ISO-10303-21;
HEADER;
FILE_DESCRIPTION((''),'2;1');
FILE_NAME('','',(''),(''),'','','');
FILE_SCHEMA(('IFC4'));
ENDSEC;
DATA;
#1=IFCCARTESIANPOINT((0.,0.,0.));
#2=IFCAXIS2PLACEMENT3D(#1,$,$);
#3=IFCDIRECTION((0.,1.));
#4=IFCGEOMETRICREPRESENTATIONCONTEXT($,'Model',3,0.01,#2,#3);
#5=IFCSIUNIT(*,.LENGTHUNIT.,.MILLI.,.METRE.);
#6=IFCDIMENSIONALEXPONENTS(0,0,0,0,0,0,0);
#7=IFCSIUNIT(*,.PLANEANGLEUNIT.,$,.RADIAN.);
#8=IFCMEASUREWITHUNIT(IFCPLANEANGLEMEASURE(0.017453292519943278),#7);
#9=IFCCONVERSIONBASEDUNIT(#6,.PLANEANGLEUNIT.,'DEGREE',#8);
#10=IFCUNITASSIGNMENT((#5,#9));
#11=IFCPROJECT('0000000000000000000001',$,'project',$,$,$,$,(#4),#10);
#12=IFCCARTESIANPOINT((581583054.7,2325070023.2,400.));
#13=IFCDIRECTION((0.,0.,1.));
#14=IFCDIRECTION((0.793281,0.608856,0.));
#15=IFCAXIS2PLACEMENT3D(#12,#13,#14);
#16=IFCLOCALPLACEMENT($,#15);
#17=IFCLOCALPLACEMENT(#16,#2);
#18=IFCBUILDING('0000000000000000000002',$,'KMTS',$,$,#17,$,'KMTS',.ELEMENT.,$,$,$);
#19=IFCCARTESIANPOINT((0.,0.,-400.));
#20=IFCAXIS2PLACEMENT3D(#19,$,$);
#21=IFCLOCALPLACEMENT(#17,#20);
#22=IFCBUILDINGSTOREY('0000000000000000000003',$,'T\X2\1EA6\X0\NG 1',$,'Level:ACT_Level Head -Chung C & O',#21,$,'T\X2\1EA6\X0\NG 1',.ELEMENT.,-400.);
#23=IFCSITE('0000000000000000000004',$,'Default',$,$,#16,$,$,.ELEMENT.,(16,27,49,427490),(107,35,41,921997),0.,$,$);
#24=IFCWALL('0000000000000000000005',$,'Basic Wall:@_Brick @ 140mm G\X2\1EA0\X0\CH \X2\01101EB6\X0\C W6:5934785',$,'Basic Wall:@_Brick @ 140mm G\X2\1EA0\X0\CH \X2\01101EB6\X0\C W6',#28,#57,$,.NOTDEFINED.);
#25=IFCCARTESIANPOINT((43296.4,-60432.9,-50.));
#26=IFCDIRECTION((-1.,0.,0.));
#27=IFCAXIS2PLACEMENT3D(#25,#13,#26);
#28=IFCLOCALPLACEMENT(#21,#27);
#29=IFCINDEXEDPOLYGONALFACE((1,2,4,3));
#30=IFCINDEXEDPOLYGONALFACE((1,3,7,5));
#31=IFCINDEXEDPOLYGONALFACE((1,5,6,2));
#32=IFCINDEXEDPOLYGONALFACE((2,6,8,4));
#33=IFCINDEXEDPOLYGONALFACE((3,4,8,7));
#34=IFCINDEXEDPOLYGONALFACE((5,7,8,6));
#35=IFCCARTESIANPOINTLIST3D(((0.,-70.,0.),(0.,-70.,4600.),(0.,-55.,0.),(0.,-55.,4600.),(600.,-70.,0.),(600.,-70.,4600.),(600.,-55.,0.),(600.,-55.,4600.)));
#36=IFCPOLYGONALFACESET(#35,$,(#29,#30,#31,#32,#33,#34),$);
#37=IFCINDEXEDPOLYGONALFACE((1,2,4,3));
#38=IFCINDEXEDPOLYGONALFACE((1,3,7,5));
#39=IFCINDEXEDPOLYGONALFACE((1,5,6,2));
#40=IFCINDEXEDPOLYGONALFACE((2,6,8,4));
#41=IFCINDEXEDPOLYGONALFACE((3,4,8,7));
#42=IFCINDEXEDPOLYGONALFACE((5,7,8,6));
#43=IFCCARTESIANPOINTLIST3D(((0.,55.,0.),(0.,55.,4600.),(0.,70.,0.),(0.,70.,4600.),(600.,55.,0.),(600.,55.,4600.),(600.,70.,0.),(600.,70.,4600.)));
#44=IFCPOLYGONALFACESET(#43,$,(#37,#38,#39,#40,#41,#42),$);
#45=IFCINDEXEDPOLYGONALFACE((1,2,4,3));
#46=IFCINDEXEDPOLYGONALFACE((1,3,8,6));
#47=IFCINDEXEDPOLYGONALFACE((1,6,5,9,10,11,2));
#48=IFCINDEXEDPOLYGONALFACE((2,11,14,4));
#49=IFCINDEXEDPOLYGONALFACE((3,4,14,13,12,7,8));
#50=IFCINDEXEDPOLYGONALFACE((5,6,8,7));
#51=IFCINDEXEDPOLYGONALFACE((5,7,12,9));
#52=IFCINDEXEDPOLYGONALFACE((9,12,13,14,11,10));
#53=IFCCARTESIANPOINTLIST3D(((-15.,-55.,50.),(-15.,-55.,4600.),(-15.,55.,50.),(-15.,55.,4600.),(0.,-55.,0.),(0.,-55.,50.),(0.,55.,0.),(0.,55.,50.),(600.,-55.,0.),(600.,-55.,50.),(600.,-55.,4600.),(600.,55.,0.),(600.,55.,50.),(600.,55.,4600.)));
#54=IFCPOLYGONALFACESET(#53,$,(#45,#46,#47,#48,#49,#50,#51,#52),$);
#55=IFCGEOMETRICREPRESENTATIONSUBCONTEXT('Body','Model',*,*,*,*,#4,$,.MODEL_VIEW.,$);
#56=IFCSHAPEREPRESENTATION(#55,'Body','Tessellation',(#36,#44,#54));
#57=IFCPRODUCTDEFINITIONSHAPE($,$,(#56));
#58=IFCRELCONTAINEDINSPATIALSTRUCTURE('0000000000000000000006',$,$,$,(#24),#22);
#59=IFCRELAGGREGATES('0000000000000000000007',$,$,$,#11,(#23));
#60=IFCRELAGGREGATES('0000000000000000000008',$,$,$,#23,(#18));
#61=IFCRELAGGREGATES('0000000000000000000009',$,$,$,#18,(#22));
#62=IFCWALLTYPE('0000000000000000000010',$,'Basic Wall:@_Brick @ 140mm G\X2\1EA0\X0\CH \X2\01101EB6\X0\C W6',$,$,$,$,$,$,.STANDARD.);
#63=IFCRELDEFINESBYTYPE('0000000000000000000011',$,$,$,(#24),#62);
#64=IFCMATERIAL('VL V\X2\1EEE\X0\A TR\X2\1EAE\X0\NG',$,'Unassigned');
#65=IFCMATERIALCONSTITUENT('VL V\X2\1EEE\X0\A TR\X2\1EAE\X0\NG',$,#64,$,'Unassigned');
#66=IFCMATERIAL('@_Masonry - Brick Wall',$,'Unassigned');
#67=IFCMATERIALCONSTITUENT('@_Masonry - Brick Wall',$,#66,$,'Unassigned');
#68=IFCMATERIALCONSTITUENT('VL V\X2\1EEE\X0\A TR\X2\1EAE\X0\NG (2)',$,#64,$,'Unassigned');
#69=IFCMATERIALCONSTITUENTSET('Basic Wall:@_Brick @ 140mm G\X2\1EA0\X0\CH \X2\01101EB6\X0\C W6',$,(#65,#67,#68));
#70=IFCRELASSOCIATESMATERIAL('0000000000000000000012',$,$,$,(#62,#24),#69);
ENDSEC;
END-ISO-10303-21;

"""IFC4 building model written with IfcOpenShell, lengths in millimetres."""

from ifc_helpers import new_model, entity, si_unit, converted_unit, direction, frame, origin, place, context, subcontext, project, spatial, indexed_curve, outline, extrude, material, constituent, constituent_set, type_object, element, save


model = new_model("IFC4")

# Units and contexts
model_context = context("Model", 3, precision=0.01, world=origin(), true_north=direction((0.0, 1.0)))
body_context = subcontext(model_context, "Body", "Model", "MODEL_VIEW")
ifc_project = project(units=[si_unit("LENGTHUNIT", "METRE", prefix="MILLI"), converted_unit("PLANEANGLEUNIT", "DEGREE", entity("IfcPlaneAngleMeasure", 0.017453292519943278), si_unit("PLANEANGLEUNIT", "RADIAN"), dimensions=[0, 0, 0, 0, 0, 0, 0])], contexts=[model_context])

# Site, building, storey
site_placement = place(None, frame((581583054.7, 2325070023.2, 400.0), z_axis=(0.0, 0.0, 1.0), x_axis=(0.793281, 0.608856, 0.0)))
site = spatial("IfcSite", under=ifc_project, at=site_placement, Name="Default", CompositionType="ELEMENT", RefLatitude=(16, 27, 49, 427490), RefLongitude=(107, 35, 41, 921997), RefElevation=0.0)
building_placement = place(site_placement, origin())
building = spatial("IfcBuilding", under=site, at=building_placement, Name="KMTS", LongName="KMTS", CompositionType="ELEMENT")
storey_placement = place(building_placement, frame((0.0, 0.0, -400.0)))
storey = spatial("IfcBuildingStorey", under=building, at=storey_placement, Name="TẦNG 1", ObjectType="Level:ACT_Level Head -Chung C & O", LongName="TẦNG 1", CompositionType="ELEMENT", Elevation=-400.0)

# Shared definitions
ifc_material_1 = material(Name="VL VỮA TRẮNG", Category="Unassigned")

# Wall
ifc_constituent_1 = constituent(ifc_material_1, Name="VL VỮA TRẮNG", Category="Unassigned")
ifc_material_2 = material(Name="@_Masonry - Brick Wall", Category="Unassigned")
ifc_constituent_2 = constituent(ifc_material_2, Name="@_Masonry - Brick Wall", Category="Unassigned")
ifc_constituent_3 = constituent(ifc_material_1, Name="VL VỮA TRẮNG (2)", Category="Unassigned")
ifc_constituent_set_1 = constituent_set(constituents=[ifc_constituent_1, ifc_constituent_2, ifc_constituent_3], Name="Basic Wall:@_Brick @ 140mm GẠCH ĐẶC W6")
wall_type_1 = type_object("IfcWallType", Name="Basic Wall:@_Brick @ 140mm GẠCH ĐẶC W6", PredefinedType="STANDARD", material=ifc_constituent_set_1)
wall_1_placement = place(storey_placement, frame((43296.4, -60432.9, -50.0), z_axis=(0.0, 0.0, 1.0), x_axis=(-1.0, 0.0, 0.0)))
element("IfcWall", 1, at=wall_1_placement, inside=storey, type_object=wall_type_1, material=ifc_constituent_set_1, Name="Basic Wall:@_Brick @ 140mm GẠCH ĐẶC W6:5934785", ObjectType="Basic Wall:@_Brick @ 140mm GẠCH ĐẶC W6", PredefinedType="NOTDEFINED", context=body_context, shape_type="SweptSolid", body=[
    extrude(outline(indexed_curve([(-7.5, -300.0), (7.5, -300.0), (7.5, 300.0), (-7.5, 300.0), (-7.5, -300.0)], self_intersect=False)), frame((300.0, -62.5, 0.0), z_axis=(0.0, 0.0, 1.0), x_axis=(0.0, 1.0, 0.0)), (0.0, 0.0, 1.0), 4600.0),
    extrude(outline(indexed_curve([(-7.5, -300.0), (7.5, -300.0), (7.5, 300.0), (-7.5, 300.0), (-7.5, -300.0)], self_intersect=False)), frame((300.0, 62.5, 0.0), z_axis=(0.0, 0.0, 1.0), x_axis=(0.0, -1.0, 0.0)), (0.0, 0.0, 1.0), 4600.0),
    extrude(outline(indexed_curve([(-1335.7, -347.1), (-1285.7, -347.1), (3264.3, -347.1), (3264.3, 267.9), (-1285.7, 267.9), (-1285.7, 252.9), (-1335.7, 252.9), (-1335.7, -347.1)], self_intersect=False)), frame((252.9, 55.0, 1335.7), z_axis=(0.0, -1.0, 0.0), x_axis=(0.0, 0.0, 1.0)), (0.0, 0.0, 1.0), 110.0),
])

save(model, "model.ifc")
